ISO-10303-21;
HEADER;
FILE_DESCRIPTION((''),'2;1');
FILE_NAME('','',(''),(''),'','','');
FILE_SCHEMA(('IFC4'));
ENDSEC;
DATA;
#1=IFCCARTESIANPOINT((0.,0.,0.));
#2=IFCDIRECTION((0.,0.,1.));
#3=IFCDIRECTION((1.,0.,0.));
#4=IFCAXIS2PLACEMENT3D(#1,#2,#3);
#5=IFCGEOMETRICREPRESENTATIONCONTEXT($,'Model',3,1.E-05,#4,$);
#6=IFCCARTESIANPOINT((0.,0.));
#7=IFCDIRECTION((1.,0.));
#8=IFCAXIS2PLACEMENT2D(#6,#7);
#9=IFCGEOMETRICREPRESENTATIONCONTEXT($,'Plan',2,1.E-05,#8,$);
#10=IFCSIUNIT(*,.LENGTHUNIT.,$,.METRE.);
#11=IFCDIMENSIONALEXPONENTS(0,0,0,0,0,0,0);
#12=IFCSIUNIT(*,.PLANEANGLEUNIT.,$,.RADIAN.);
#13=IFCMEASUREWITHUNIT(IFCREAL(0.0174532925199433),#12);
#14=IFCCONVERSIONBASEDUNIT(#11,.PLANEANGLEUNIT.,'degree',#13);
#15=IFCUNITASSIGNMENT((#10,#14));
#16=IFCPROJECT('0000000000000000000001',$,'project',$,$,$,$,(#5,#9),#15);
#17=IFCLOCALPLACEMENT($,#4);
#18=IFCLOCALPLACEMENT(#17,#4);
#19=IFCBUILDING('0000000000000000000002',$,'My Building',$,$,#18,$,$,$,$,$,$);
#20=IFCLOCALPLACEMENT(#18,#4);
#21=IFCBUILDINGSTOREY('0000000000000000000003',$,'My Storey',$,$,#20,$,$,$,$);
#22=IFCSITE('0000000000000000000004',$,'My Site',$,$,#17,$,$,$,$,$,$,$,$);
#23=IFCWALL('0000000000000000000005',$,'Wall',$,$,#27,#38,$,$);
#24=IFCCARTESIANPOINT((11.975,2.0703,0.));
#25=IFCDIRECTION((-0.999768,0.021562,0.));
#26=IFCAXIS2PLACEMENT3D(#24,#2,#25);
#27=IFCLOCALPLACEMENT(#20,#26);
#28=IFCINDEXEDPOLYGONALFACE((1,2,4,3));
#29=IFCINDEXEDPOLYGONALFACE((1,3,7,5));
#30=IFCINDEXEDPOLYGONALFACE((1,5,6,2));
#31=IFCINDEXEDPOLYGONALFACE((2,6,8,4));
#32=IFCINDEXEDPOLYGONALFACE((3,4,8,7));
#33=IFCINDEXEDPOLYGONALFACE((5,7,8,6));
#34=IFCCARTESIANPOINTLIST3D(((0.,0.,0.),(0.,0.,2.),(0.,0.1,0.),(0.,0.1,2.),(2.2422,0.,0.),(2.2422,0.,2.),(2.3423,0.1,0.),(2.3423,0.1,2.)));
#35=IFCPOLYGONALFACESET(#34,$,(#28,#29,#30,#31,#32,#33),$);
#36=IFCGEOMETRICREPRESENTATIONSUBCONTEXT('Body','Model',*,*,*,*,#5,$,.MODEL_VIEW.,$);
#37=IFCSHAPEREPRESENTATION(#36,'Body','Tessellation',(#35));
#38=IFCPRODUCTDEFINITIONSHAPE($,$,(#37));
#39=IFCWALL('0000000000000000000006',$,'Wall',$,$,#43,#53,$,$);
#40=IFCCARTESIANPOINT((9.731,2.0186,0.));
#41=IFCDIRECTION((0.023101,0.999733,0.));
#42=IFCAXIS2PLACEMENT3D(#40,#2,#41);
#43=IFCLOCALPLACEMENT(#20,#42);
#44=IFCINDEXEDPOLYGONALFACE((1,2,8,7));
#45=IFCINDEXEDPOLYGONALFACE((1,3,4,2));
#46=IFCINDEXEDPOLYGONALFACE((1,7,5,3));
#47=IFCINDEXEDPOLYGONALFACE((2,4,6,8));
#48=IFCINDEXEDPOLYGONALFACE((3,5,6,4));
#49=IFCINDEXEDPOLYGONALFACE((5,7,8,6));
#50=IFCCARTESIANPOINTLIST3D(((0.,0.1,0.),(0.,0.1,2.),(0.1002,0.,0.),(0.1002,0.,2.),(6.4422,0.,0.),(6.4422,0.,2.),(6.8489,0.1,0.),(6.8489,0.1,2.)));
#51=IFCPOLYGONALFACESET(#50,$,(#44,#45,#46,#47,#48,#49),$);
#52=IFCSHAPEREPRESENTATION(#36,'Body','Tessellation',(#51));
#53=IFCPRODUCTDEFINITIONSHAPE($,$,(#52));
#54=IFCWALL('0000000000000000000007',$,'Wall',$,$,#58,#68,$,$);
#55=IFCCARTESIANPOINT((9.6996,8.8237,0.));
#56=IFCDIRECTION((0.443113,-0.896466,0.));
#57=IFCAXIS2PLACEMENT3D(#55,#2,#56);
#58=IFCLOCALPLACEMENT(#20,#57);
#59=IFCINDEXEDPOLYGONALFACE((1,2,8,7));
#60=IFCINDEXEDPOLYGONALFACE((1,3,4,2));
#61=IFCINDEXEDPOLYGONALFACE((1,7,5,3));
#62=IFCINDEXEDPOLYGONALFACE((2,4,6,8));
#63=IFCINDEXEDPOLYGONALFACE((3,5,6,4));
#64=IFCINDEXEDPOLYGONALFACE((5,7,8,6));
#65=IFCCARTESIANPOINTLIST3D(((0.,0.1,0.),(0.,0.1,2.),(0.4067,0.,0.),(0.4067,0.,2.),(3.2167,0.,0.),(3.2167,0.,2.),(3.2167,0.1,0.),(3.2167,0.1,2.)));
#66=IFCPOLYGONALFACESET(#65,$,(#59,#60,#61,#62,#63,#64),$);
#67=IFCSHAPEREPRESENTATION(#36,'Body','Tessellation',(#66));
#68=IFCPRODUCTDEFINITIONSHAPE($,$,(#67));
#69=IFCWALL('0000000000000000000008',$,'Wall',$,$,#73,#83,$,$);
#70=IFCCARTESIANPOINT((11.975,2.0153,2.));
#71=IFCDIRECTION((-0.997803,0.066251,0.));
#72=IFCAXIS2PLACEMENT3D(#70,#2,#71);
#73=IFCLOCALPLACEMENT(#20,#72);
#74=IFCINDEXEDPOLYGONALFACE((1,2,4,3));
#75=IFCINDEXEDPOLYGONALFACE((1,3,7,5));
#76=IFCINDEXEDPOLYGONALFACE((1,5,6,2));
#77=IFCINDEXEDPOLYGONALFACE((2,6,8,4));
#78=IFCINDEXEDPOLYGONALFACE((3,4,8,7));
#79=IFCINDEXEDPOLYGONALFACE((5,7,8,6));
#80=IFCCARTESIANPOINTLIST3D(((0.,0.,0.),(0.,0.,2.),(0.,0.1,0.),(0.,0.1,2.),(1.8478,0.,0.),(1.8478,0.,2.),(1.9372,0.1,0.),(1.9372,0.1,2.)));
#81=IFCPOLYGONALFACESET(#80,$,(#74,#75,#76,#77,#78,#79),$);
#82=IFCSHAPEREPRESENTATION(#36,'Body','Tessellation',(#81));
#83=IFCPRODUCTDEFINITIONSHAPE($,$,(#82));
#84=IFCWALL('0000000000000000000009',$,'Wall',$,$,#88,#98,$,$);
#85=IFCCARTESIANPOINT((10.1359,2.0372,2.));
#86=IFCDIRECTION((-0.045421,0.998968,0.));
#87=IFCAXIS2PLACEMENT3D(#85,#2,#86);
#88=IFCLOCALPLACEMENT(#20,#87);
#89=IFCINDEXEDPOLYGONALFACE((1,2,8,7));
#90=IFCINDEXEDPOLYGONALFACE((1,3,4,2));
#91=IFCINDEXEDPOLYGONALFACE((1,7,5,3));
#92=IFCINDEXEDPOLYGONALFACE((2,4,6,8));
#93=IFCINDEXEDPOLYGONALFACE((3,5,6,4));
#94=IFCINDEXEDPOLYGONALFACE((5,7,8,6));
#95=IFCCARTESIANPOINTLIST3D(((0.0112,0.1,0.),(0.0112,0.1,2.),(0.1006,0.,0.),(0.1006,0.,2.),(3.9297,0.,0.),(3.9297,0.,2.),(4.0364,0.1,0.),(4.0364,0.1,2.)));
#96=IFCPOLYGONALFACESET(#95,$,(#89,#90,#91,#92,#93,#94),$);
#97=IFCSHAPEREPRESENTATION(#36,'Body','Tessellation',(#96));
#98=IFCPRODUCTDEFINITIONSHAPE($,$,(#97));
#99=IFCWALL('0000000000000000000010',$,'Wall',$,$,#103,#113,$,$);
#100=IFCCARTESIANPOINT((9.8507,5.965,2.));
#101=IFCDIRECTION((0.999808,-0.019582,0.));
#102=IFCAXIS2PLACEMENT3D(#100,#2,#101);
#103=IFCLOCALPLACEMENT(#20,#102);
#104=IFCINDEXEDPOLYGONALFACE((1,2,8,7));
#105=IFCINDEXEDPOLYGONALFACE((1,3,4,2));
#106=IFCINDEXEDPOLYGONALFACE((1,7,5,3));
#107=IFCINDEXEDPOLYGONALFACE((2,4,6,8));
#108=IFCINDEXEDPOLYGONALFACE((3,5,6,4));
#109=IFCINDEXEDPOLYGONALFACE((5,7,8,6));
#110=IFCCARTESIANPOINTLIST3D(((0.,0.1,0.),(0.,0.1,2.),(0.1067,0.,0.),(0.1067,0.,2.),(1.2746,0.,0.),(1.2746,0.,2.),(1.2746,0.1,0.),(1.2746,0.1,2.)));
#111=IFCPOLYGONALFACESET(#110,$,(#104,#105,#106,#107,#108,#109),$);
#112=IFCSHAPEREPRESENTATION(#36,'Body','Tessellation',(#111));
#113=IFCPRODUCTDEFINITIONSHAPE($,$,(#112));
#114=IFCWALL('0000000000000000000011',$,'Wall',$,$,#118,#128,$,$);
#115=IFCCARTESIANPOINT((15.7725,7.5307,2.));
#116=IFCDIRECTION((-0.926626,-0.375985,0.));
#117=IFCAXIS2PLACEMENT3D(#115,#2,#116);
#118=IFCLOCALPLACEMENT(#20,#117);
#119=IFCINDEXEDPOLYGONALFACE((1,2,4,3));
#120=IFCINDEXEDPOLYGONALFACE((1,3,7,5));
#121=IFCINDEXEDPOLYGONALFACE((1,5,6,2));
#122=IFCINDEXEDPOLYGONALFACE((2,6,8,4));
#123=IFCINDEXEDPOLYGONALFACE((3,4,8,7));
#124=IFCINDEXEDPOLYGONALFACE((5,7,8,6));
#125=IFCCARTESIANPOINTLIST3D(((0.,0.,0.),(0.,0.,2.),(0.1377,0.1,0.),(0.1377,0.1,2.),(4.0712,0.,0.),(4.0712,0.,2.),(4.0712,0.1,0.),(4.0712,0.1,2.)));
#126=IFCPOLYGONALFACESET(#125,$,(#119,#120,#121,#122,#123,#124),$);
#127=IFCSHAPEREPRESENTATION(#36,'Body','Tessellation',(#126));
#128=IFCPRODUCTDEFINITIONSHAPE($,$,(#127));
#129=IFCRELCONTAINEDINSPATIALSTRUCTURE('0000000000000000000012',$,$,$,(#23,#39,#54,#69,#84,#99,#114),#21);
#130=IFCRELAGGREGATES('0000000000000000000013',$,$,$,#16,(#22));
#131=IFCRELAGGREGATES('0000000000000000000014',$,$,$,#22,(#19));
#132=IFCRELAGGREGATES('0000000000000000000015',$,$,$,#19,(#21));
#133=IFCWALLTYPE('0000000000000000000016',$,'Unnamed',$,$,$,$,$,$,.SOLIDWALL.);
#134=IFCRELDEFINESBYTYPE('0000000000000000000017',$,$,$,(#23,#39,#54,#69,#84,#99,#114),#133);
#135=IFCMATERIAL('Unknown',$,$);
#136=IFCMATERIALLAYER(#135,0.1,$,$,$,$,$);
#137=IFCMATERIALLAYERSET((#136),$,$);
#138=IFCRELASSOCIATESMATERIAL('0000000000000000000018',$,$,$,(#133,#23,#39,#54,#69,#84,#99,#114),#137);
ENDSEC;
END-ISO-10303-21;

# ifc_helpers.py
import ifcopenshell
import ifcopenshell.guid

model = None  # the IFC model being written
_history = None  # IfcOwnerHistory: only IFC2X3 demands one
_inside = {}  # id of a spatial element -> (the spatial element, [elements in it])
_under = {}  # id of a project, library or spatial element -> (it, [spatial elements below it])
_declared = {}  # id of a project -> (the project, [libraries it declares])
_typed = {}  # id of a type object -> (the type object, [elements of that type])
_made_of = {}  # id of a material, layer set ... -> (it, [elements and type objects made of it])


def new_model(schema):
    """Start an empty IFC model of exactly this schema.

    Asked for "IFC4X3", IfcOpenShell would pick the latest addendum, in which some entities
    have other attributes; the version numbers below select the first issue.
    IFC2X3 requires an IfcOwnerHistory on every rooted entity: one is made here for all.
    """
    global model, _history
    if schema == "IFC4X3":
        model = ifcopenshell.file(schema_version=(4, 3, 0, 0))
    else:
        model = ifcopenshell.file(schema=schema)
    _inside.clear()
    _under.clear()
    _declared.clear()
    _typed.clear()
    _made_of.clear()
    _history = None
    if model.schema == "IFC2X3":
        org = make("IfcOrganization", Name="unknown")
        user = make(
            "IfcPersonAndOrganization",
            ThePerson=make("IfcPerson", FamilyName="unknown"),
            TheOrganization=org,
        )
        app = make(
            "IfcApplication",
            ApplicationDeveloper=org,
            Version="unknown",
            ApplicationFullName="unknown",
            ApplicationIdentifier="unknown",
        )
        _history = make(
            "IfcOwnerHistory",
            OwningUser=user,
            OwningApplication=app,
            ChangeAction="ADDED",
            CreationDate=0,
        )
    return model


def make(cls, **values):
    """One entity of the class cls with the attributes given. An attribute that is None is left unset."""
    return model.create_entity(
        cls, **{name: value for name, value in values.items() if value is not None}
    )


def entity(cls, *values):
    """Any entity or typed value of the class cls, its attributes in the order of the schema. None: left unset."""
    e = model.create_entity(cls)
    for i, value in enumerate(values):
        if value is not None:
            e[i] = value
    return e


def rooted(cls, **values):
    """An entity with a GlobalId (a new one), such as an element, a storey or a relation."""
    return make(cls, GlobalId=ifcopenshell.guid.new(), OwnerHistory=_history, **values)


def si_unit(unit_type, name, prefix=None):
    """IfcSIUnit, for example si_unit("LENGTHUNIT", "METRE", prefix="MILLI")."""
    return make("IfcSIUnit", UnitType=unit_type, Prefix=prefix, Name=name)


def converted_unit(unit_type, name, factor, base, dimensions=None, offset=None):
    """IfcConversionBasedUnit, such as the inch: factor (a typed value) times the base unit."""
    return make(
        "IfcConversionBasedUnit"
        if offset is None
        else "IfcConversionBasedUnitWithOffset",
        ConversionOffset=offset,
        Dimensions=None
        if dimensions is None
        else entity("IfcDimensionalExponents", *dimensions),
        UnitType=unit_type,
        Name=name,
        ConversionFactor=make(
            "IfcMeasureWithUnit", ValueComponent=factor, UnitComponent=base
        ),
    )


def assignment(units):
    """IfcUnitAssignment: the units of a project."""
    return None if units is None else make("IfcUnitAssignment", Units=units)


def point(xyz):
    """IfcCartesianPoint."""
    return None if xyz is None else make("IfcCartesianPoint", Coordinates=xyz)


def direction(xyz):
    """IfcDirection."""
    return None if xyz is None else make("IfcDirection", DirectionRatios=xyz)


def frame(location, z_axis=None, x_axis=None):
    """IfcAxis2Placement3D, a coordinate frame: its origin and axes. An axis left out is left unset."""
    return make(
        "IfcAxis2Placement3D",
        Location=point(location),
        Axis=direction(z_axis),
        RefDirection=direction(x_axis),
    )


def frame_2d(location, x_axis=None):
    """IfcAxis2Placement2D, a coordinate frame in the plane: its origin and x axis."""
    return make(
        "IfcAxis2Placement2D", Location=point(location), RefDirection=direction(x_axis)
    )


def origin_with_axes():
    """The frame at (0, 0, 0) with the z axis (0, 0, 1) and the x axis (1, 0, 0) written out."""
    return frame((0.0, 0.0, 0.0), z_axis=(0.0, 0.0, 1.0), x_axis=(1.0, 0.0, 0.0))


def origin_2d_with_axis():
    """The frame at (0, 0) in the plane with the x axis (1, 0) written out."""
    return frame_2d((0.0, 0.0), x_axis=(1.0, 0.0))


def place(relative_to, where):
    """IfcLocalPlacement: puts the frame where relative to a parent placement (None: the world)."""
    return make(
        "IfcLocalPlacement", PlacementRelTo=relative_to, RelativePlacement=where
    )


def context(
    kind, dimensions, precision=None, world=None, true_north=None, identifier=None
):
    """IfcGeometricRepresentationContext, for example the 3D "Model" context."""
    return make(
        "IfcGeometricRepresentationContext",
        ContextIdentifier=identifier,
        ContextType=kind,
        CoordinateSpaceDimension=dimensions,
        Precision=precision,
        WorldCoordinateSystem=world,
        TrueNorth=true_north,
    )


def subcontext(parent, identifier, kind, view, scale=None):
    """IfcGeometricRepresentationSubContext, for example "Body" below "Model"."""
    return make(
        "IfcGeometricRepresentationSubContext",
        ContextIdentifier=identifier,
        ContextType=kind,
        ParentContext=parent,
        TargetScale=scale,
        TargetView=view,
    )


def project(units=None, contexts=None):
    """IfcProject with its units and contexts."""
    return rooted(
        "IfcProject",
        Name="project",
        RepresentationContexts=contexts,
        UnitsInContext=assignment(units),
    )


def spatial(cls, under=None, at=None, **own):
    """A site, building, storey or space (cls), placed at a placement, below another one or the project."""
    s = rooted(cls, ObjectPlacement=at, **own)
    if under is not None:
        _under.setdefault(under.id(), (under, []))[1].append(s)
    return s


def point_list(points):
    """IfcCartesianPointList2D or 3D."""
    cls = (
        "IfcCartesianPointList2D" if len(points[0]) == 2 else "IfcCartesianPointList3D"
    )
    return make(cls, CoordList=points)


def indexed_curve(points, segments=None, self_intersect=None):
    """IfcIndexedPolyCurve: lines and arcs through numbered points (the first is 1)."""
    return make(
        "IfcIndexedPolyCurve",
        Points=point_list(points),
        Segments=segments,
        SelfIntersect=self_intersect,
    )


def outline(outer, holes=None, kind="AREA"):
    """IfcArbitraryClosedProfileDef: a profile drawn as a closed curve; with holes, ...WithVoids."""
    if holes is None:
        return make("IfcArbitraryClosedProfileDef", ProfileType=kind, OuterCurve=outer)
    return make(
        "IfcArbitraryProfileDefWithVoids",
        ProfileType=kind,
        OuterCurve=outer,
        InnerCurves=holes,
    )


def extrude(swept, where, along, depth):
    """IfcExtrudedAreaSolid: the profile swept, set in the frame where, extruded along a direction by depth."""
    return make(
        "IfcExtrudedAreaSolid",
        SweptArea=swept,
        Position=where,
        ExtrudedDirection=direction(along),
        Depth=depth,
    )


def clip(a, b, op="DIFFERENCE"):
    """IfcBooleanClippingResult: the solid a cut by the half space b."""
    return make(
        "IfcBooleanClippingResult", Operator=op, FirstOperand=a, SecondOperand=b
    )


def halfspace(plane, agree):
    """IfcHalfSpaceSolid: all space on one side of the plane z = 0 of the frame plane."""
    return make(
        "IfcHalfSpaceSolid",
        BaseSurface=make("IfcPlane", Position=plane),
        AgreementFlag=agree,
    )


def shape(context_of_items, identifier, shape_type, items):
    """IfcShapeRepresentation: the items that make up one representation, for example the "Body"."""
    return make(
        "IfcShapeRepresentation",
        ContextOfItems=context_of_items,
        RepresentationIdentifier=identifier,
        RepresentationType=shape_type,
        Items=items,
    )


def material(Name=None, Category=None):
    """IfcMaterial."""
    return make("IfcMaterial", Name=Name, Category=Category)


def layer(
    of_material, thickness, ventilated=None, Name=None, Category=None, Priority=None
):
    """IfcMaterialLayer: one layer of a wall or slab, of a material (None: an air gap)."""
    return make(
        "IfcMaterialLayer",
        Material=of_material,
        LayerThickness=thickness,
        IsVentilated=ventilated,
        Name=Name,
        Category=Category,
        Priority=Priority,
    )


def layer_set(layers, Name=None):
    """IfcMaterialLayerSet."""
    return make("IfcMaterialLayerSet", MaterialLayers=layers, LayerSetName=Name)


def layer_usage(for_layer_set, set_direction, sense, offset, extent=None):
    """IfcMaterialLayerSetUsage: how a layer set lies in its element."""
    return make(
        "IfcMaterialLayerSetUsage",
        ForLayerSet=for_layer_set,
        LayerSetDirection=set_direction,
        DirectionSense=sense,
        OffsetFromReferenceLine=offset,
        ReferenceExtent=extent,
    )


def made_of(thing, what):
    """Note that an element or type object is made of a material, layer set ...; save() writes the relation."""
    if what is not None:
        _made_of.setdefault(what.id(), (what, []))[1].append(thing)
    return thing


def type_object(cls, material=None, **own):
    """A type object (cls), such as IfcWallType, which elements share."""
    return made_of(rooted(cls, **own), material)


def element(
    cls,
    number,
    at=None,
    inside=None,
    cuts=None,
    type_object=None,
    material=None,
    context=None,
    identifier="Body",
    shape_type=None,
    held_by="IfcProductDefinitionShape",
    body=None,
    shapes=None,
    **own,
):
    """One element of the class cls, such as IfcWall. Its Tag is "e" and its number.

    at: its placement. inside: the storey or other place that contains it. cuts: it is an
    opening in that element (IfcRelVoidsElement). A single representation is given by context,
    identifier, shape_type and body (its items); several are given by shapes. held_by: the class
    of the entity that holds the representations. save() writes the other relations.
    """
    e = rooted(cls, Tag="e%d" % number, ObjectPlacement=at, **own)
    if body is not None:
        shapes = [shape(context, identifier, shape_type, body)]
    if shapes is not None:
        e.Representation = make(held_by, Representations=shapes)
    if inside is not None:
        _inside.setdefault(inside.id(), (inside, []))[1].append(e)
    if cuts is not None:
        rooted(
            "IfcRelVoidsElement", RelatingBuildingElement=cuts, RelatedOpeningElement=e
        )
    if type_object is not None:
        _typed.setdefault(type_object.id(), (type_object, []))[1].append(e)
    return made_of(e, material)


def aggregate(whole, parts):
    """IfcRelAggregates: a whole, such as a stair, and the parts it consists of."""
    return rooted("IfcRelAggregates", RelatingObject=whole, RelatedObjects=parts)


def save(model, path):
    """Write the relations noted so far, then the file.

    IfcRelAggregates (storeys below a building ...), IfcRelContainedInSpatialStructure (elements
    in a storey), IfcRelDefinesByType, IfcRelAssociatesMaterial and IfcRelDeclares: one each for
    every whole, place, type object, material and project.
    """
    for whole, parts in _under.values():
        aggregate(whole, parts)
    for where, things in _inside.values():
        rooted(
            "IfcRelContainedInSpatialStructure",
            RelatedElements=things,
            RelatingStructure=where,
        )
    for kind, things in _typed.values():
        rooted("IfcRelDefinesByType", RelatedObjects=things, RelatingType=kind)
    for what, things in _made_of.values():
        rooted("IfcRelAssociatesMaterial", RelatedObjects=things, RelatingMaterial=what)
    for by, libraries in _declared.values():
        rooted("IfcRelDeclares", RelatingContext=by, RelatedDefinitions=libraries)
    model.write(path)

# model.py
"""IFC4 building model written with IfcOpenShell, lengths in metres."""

from ifc_helpers import new_model, entity, si_unit, converted_unit, frame, origin_with_axes, origin_2d_with_axis, place, context, subcontext, project, spatial, indexed_curve, outline, extrude, clip, halfspace, material, layer, layer_set, layer_usage, type_object, element, save


model = new_model("IFC4")

# Units and contexts
model_context = context("Model", 3, precision=1e-05, world=origin_with_axes())
plan_context = context("Plan", 2, precision=1e-05, world=origin_2d_with_axis())
body_context_1 = subcontext(model_context, "Body", "Model", "MODEL_VIEW")
ifc_project = project(units=[si_unit("LENGTHUNIT", "METRE"), converted_unit("PLANEANGLEUNIT", "degree", entity("IfcReal", 0.0174532925199433), si_unit("PLANEANGLEUNIT", "RADIAN"), dimensions=[0, 0, 0, 0, 0, 0, 0])], contexts=[model_context, plan_context])

# Site, building, storey
site_placement = place(None, origin_with_axes())
site = spatial("IfcSite", under=ifc_project, at=site_placement, Name="My Site")
building_placement = place(site_placement, origin_with_axes())
building = spatial("IfcBuilding", under=site, at=building_placement, Name="My Building")
storey_placement = place(building_placement, origin_with_axes())
storey = spatial("IfcBuildingStorey", under=building, at=storey_placement, Name="My Storey")

# Shared definitions
ifc_material = material(Name="Unknown")

# Walls
ifc_layer_1 = layer(ifc_material, 0.1)
ifc_layer_set_1 = layer_set([ifc_layer_1])
wall_type = type_object("IfcWallType", Name="Unnamed", PredefinedType="SOLIDWALL", material=ifc_layer_set_1)
ifc_layer_usage_1 = layer_usage(ifc_layer_set_1, "AXIS2", "POSITIVE", 0.0)
wall_1_placement = place(storey_placement, frame((11.975, 2.0703, 0.0), z_axis=(0.0, 0.0, 1.0), x_axis=(-0.999768, 0.021562, 0.0)))
element("IfcWall", 1, at=wall_1_placement, inside=storey, type_object=wall_type, material=ifc_layer_usage_1, Name="Wall", context=body_context_1, shape_type="Clipping", body=[
    clip(extrude(outline(indexed_curve([(0.0, 0.0), (0.0, 0.1), (2.3423, 0.1), (2.3423, 0.0), (0.0, 0.0)], self_intersect=False)), origin_with_axes(), (0.0, 0.0, 1.0), 2.0), halfspace(frame((2.2422, 0.0, 0.0), z_axis=(0.706564, -0.70765, 0.0), x_axis=(-0.70765, -0.706564, 0.0)), False)),
])
ifc_layer_usage_2 = layer_usage(ifc_layer_set_1, "AXIS2", "POSITIVE", 0.0)
wall_2_placement = place(storey_placement, frame((9.731, 2.0186, 0.0), z_axis=(0.0, 0.0, 1.0), x_axis=(0.023101, 0.999733, 0.0)))
element("IfcWall", 2, at=wall_2_placement, inside=storey, type_object=wall_type, material=ifc_layer_usage_2, Name="Wall", context=body_context_1, shape_type="Clipping", body=[
    clip(clip(extrude(outline(indexed_curve([(0.0, 0.0), (0.0, 0.1), (6.8489, 0.1), (6.8489, 0.0), (0.0, 0.0)], self_intersect=False)), origin_with_axes(), (0.0, 0.0, 1.0), 2.0), halfspace(frame((6.4422, 0.0, 0.0), z_axis=(0.238758, -0.971079, 0.0), x_axis=(-0.971079, -0.238758, 0.0)), False)), halfspace(frame((0.1002, 0.0, 0.0), z_axis=(-0.70656, -0.707653, 0.0), x_axis=(-0.707653, 0.70656, 0.0)), False)),
])
ifc_layer_usage_3 = layer_usage(ifc_layer_set_1, "AXIS2", "POSITIVE", 0.0)
wall_3_placement = place(storey_placement, frame((9.6996, 8.8237, 0.0), z_axis=(0.0, 0.0, 1.0), x_axis=(0.443113, -0.896466, 0.0)))
element("IfcWall", 3, at=wall_3_placement, inside=storey, type_object=wall_type, material=ifc_layer_usage_3, Name="Wall", context=body_context_1, shape_type="Clipping", body=[
    clip(extrude(outline(indexed_curve([(0.0, 0.0), (0.0, 0.1), (3.2167, 0.1), (3.2167, 0.0), (0.0, 0.0)], self_intersect=False)), origin_with_axes(), (0.0, 0.0, 1.0), 2.0), halfspace(frame((0.4067, 0.0, 0.0), z_axis=(-0.238757, -0.971079, 0.0), x_axis=(-0.971079, 0.238757, 0.0)), False)),
])
ifc_layer_usage_4 = layer_usage(ifc_layer_set_1, "AXIS2", "POSITIVE", 0.0)
wall_4_placement = place(storey_placement, frame((11.975, 2.0153, 2.0), z_axis=(0.0, 0.0, 1.0), x_axis=(-0.997803, 0.066251, 0.0)))
element("IfcWall", 4, at=wall_4_placement, inside=storey, type_object=wall_type, material=ifc_layer_usage_4, Name="Wall", context=body_context_1, shape_type="Clipping", body=[
    clip(extrude(outline(indexed_curve([(0.0, 0.0), (0.0, 0.1), (1.9484, 0.1), (1.9484, 0.0), (0.0, 0.0)], self_intersect=False)), origin_with_axes(), (0.0, 0.0, 1.0), 2.0), halfspace(frame((1.8478, 0.0, -2.0), z_axis=(0.745485, -0.666522, 0.0), x_axis=(-0.666522, -0.745485, 0.0)), False)),
])
ifc_layer_usage_5 = layer_usage(ifc_layer_set_1, "AXIS2", "POSITIVE", 0.0)
wall_5_placement = place(storey_placement, frame((10.1359, 2.0372, 2.0), z_axis=(0.0, 0.0, 1.0), x_axis=(-0.045421, 0.998968, 0.0)))
element("IfcWall", 5, at=wall_5_placement, inside=storey, type_object=wall_type, material=ifc_layer_usage_5, Name="Wall", context=body_context_1, shape_type="Clipping", body=[
    clip(clip(extrude(outline(indexed_curve([(0.0, 0.0), (0.0, 0.1), (4.0364, 0.1), (4.0364, 0.0), (0.0, 0.0)], self_intersect=False)), origin_with_axes(), (0.0, 0.0, 1.0), 2.0), halfspace(frame((3.9297, 0.0, -2.0), z_axis=(0.683758, -0.729709, 0.0), x_axis=(-0.729709, -0.683758, 0.0)), False)), halfspace(frame((0.1006, 0.0, -2.0), z_axis=(-0.745494, -0.666512, 0.0), x_axis=(-0.666512, 0.745494, 0.0)), False)),
])
ifc_layer_usage_6 = layer_usage(ifc_layer_set_1, "AXIS2", "POSITIVE", 0.0)
wall_6_placement = place(storey_placement, frame((9.8507, 5.965, 2.0), z_axis=(0.0, 0.0, 1.0), x_axis=(0.999808, -0.019582, 0.0)))
element("IfcWall", 6, at=wall_6_placement, inside=storey, type_object=wall_type, material=ifc_layer_usage_6, Name="Wall", context=body_context_1, shape_type="Clipping", body=[
    clip(extrude(outline(indexed_curve([(0.0, 0.0), (0.0, 0.1), (1.2746, 0.1), (1.2746, 0.0), (0.0, 0.0)], self_intersect=False)), origin_with_axes(), (0.0, 0.0, 1.0), 2.0), halfspace(frame((0.1067, 0.0, -2.0), z_axis=(-0.683744, -0.729722, 0.0), x_axis=(-0.729722, 0.683744, 0.0)), False)),
])
ifc_layer_usage_7 = layer_usage(ifc_layer_set_1, "AXIS2", "POSITIVE", 0.0)
wall_7_placement = place(storey_placement, frame((15.7725, 7.5307, 2.0), z_axis=(0.0, 0.0, 1.0), x_axis=(-0.926626, -0.375985, 0.0)))
element("IfcWall", 7, at=wall_7_placement, inside=storey, type_object=wall_type, material=ifc_layer_usage_7, Name="Wall", context=body_context_1, shape_type="Clipping", body=[
    clip(extrude(outline(indexed_curve([(0.0, 0.0), (0.0, 0.1), (4.0712, 0.1), (4.0712, 0.0), (0.0, 0.0)], self_intersect=False)), origin_with_axes(), (0.0, 0.0, 1.0), 2.0), halfspace(frame((0.0, 0.0, -2.0), z_axis=(-0.587596, 0.809155, 0.0), x_axis=(0.809155, 0.587596, 0.0)), False)),
])

save(model, "model.ifc")
